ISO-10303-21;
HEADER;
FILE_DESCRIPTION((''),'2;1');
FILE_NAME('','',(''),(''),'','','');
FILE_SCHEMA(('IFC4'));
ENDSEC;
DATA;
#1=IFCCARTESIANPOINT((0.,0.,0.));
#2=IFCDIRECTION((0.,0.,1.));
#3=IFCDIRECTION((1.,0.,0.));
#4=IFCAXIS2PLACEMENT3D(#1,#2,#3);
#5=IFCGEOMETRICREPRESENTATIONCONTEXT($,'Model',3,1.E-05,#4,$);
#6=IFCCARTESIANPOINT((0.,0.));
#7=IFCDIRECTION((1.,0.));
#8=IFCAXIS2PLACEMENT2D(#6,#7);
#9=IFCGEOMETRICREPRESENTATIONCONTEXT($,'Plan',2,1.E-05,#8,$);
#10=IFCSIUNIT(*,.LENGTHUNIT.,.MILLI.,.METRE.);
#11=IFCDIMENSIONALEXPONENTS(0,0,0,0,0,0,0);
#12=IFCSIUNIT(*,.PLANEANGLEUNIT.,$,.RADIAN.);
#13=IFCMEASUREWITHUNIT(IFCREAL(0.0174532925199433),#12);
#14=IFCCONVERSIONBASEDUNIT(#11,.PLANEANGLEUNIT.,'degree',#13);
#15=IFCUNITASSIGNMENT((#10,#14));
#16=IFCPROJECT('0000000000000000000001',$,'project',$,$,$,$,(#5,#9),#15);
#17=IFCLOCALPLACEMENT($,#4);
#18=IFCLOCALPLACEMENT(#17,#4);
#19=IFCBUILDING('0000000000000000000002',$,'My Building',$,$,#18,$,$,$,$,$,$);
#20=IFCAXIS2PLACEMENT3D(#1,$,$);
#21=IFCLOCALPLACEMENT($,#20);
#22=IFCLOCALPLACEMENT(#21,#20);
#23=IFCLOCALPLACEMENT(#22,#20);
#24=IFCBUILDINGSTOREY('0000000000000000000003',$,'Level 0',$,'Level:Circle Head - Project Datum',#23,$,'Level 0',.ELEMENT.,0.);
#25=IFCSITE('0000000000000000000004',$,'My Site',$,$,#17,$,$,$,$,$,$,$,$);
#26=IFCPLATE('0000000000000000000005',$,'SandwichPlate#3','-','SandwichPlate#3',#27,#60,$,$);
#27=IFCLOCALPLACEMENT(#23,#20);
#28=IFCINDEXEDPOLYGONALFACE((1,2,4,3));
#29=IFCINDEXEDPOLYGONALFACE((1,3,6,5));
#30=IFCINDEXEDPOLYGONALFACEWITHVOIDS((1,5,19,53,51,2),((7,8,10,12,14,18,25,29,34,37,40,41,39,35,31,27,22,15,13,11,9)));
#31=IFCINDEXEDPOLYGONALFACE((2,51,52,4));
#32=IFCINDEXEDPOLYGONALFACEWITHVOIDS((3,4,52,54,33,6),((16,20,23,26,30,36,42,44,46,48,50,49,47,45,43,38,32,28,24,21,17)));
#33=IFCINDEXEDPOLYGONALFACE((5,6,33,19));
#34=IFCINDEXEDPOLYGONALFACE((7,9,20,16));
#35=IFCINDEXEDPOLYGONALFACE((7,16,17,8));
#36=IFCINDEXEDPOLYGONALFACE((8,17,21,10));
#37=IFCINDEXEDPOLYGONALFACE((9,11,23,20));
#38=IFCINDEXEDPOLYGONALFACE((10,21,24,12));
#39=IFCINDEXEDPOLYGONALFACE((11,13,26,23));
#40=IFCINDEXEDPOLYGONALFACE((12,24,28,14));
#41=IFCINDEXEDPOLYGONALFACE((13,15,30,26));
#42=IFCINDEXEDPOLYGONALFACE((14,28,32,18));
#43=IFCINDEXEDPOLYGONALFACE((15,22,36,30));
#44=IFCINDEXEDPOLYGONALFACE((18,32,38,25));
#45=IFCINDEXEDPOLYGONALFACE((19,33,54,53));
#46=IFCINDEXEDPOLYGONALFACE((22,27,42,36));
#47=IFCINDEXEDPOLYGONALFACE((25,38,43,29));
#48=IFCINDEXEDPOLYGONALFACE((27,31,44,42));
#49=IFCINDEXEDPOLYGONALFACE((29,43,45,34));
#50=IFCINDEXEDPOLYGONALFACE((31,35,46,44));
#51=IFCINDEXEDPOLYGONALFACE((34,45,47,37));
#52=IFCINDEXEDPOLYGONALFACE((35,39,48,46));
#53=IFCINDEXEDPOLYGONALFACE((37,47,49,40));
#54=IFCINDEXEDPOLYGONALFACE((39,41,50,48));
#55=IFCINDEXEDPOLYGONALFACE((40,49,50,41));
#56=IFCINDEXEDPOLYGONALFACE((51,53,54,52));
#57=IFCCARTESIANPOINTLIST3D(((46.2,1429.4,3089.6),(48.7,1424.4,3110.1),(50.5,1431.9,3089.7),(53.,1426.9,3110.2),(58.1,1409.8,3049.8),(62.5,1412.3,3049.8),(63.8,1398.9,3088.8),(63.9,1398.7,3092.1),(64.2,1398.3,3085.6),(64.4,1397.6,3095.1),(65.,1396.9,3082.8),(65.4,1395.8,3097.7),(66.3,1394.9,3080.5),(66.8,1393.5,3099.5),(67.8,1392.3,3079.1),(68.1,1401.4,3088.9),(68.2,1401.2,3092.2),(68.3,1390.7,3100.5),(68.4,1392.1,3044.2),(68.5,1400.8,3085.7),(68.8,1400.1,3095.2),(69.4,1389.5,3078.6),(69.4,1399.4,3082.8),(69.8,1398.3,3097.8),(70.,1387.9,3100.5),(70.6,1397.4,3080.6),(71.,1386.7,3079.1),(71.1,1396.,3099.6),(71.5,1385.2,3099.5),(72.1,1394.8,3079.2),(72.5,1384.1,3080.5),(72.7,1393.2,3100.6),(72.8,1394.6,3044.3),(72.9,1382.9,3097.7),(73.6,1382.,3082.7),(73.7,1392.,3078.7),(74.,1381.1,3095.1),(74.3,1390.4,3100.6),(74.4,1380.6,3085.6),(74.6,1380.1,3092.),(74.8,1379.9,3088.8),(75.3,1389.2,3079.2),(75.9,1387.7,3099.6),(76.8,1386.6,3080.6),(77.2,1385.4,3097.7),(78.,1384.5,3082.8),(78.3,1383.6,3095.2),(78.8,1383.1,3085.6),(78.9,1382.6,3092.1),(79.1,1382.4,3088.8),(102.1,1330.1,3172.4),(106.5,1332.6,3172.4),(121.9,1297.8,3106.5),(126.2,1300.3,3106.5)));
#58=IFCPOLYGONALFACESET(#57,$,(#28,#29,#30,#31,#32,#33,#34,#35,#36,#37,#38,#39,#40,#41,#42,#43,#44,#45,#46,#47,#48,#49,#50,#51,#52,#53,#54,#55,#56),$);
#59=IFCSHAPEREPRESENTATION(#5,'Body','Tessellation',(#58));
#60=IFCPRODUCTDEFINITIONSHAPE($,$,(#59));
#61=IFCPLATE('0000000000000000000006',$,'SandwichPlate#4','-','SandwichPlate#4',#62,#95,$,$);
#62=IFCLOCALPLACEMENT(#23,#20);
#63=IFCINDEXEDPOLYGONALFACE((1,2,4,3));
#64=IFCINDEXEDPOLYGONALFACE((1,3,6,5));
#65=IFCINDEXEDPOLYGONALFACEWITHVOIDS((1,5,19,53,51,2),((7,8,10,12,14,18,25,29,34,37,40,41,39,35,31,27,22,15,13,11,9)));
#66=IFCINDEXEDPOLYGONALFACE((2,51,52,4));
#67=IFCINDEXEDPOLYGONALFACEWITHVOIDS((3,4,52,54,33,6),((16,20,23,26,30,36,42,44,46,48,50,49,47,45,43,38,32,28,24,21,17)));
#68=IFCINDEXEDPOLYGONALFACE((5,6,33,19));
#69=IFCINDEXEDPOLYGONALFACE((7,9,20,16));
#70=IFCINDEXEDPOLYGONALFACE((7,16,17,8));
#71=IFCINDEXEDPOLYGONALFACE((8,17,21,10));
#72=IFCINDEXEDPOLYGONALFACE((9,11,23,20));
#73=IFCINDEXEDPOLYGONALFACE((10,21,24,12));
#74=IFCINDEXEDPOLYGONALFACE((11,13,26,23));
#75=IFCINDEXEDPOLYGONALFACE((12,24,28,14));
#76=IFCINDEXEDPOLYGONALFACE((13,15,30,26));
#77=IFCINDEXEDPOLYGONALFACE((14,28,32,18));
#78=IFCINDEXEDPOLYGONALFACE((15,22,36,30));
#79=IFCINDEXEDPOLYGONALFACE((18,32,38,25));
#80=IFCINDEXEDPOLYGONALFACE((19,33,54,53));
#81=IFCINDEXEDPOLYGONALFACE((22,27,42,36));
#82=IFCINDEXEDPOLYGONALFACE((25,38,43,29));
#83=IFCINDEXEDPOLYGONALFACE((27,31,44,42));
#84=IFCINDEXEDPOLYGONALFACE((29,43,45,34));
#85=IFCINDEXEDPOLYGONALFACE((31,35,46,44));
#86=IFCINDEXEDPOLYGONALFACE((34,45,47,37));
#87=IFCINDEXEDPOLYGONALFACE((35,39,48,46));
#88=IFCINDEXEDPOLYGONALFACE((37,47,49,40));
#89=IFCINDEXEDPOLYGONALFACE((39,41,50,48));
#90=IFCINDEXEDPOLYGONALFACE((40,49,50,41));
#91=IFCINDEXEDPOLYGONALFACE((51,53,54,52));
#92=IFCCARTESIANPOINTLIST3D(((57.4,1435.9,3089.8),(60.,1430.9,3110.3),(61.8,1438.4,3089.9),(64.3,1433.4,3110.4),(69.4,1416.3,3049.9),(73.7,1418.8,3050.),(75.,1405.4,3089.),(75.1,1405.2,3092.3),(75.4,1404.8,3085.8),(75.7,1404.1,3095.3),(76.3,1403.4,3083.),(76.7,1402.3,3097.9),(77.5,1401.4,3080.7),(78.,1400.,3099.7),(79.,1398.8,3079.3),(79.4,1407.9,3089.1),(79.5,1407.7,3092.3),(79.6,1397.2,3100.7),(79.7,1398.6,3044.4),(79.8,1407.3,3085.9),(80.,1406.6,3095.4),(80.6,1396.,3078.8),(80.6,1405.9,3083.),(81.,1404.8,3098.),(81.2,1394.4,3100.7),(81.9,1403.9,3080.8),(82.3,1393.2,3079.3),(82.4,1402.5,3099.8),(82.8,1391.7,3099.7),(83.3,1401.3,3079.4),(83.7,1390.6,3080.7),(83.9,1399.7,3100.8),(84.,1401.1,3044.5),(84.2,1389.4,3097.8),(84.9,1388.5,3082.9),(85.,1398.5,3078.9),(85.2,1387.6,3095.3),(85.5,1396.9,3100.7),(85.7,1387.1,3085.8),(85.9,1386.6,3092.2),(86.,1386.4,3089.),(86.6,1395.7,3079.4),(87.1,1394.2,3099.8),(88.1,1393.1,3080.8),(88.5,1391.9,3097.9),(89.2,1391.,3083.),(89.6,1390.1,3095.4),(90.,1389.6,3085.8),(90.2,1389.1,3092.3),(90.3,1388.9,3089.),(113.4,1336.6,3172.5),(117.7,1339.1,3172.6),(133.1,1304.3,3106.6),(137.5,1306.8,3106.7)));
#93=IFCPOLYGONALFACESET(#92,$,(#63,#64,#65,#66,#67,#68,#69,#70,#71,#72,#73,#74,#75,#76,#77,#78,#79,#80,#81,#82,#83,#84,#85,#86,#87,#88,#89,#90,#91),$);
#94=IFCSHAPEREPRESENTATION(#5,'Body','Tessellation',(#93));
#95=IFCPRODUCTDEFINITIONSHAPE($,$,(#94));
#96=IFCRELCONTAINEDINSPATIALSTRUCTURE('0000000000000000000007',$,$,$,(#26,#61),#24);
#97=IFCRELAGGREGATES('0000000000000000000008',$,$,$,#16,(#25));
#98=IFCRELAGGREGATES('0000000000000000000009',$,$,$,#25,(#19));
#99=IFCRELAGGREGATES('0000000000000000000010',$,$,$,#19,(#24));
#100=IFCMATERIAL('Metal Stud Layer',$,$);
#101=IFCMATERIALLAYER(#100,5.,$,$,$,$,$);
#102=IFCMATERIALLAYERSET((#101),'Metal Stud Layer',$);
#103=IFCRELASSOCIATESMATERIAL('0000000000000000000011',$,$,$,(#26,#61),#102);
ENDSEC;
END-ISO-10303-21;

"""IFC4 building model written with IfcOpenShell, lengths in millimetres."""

from ifc_helpers import new_model, entity, si_unit, converted_unit, frame, origin, origin_with_axes, origin_2d_with_axis, place, context, project, spatial, polyline, circle, outline, extrude, material, layer, layer_set, element, save


model = new_model("IFC4")

# Units and contexts
model_context = context("Model", 3, precision=1e-05, world=origin_with_axes())
plan_context = context("Plan", 2, precision=1e-05, world=origin_2d_with_axis())
ifc_project = project(units=[si_unit("LENGTHUNIT", "METRE", prefix="MILLI"), converted_unit("PLANEANGLEUNIT", "degree", entity("IfcReal", 0.0174532925199433), si_unit("PLANEANGLEUNIT", "RADIAN"), dimensions=[0, 0, 0, 0, 0, 0, 0])], contexts=[model_context, plan_context])

# Site, building, storey
site_placement = place(None, origin_with_axes())
site = spatial("IfcSite", under=ifc_project, at=site_placement, Name="My Site")
building_placement = place(site_placement, origin_with_axes())
building = spatial("IfcBuilding", under=site, at=building_placement, Name="My Building")
placement_1 = place(None, origin())
placement_2 = place(placement_1, origin())
storey_placement = place(placement_2, origin())
storey = spatial("IfcBuildingStorey", under=building, at=storey_placement, Name="Level 0", ObjectType="Level:Circle Head - Project Datum", LongName="Level 0", CompositionType="ELEMENT", Elevation=0.0)

# Plates, openings
ifc_material_1 = material(Name="Metal Stud Layer")
ifc_layer_1 = layer(ifc_material_1, 5.0)
ifc_layer_set_1 = layer_set([ifc_layer_1], Name="Metal Stud Layer")
plate_1_placement = place(storey_placement, frame((62.0, 1403.5, 3036.7), z_axis=(0.865935, 0.499948, 0.014432), x_axis=(-0.259821, 0.424992, 0.867107)))
plate_1 = element("IfcPlate", 1, at=plate_1_placement, inside=storey, material=ifc_layer_set_1, Name="SandwichPlate#3", Description="-", ObjectType="SandwichPlate#3", context=model_context, shape_type="SweptSolid", body=[
    extrude(outline(polyline([(0.0, 0.0), (76.0, 0.0), (76.0, 140.0), (0.0, 140.0), (0.0, 0.0)])), origin_with_axes(), (0.0, 0.0, 1.0), 5.0),
])
opening_1_placement = place(plate_1_placement, frame((0.0, 0.0, 0.0), z_axis=(0.0, 0.0, 1.0), x_axis=(1.0, 0.0, 0.0)))
element("IfcOpeningElement", 2, at=opening_1_placement, cuts=plate_1, ObjectType="Opening", context=model_context, shape_type="SweptSolid", body=[
    extrude(outline(polyline([(76.0, 0.0), (76.0, 15.0), (61.0, 0.0), (76.0, 0.0)])), origin(), (0.0, 0.0, 1.0), 5.0),
])
opening_2_placement = place(plate_1_placement, frame((38.0, 40.0, -0.5), z_axis=(0.0, 0.0, 1.0), x_axis=(0.0, 1.0, 0.0)))
element("IfcOpeningElement", 3, at=opening_2_placement, cuts=plate_1, ObjectType="Opening", context=model_context, shape_type="SweptSolid", body=[
    extrude(circle(Radius=11.0, at=origin_2d_with_axis()), origin(), (0.0, 0.0, 1.0), 6.0),
])
opening_3_placement = place(plate_1_placement, frame((0.0, 0.0, 0.0), z_axis=(0.0, 0.0, 1.0), x_axis=(1.0, 0.0, 0.0)))
element("IfcOpeningElement", 4, at=opening_3_placement, cuts=plate_1, ObjectType="Opening", context=model_context, shape_type="SweptSolid", body=[
    extrude(outline(polyline([(0.0, 0.0), (15.0, 0.0), (0.0, 15.0), (0.0, 0.0)])), origin(), (0.0, 0.0, 1.0), 5.0),
])
plate_2_placement = place(storey_placement, frame((73.3, 1410.0, 3036.9), z_axis=(0.865935, 0.499948, 0.014432), x_axis=(-0.259821, 0.424992, 0.867107)))
plate_2 = element("IfcPlate", 5, at=plate_2_placement, inside=storey, material=ifc_layer_set_1, Name="SandwichPlate#4", Description="-", ObjectType="SandwichPlate#4", context=model_context, shape_type="SweptSolid", body=[
    extrude(outline(polyline([(0.0, 0.0), (76.0, 0.0), (76.0, 140.0), (0.0, 140.0), (0.0, 0.0)])), origin_with_axes(), (0.0, 0.0, 1.0), 5.0),
])
opening_4_placement = place(plate_2_placement, frame((0.0, 0.0, 0.0), z_axis=(0.0, 0.0, 1.0), x_axis=(1.0, 0.0, 0.0)))
element("IfcOpeningElement", 6, at=opening_4_placement, cuts=plate_2, ObjectType="Opening", context=model_context, shape_type="SweptSolid", body=[
    extrude(outline(polyline([(76.0, 0.0), (76.0, 15.0), (61.0, 0.0), (76.0, 0.0)])), origin(), (0.0, 0.0, 1.0), 5.0),
])
opening_5_placement = place(plate_2_placement, frame((38.0, 40.0, -0.5), z_axis=(0.0, 0.0, 1.0), x_axis=(0.0, 1.0, 0.0)))
element("IfcOpeningElement", 7, at=opening_5_placement, cuts=plate_2, ObjectType="Opening", context=model_context, shape_type="SweptSolid", body=[
    extrude(circle(Radius=11.0, at=origin_2d_with_axis()), origin(), (0.0, 0.0, 1.0), 6.0),
])
opening_6_placement = place(plate_2_placement, frame((0.0, 0.0, 0.0), z_axis=(0.0, 0.0, 1.0), x_axis=(1.0, 0.0, 0.0)))
element("IfcOpeningElement", 8, at=opening_6_placement, cuts=plate_2, ObjectType="Opening", context=model_context, shape_type="SweptSolid", body=[
    extrude(outline(polyline([(0.0, 0.0), (15.0, 0.0), (0.0, 15.0), (0.0, 0.0)])), origin(), (0.0, 0.0, 1.0), 5.0),
])

save(model, "model.ifc")
